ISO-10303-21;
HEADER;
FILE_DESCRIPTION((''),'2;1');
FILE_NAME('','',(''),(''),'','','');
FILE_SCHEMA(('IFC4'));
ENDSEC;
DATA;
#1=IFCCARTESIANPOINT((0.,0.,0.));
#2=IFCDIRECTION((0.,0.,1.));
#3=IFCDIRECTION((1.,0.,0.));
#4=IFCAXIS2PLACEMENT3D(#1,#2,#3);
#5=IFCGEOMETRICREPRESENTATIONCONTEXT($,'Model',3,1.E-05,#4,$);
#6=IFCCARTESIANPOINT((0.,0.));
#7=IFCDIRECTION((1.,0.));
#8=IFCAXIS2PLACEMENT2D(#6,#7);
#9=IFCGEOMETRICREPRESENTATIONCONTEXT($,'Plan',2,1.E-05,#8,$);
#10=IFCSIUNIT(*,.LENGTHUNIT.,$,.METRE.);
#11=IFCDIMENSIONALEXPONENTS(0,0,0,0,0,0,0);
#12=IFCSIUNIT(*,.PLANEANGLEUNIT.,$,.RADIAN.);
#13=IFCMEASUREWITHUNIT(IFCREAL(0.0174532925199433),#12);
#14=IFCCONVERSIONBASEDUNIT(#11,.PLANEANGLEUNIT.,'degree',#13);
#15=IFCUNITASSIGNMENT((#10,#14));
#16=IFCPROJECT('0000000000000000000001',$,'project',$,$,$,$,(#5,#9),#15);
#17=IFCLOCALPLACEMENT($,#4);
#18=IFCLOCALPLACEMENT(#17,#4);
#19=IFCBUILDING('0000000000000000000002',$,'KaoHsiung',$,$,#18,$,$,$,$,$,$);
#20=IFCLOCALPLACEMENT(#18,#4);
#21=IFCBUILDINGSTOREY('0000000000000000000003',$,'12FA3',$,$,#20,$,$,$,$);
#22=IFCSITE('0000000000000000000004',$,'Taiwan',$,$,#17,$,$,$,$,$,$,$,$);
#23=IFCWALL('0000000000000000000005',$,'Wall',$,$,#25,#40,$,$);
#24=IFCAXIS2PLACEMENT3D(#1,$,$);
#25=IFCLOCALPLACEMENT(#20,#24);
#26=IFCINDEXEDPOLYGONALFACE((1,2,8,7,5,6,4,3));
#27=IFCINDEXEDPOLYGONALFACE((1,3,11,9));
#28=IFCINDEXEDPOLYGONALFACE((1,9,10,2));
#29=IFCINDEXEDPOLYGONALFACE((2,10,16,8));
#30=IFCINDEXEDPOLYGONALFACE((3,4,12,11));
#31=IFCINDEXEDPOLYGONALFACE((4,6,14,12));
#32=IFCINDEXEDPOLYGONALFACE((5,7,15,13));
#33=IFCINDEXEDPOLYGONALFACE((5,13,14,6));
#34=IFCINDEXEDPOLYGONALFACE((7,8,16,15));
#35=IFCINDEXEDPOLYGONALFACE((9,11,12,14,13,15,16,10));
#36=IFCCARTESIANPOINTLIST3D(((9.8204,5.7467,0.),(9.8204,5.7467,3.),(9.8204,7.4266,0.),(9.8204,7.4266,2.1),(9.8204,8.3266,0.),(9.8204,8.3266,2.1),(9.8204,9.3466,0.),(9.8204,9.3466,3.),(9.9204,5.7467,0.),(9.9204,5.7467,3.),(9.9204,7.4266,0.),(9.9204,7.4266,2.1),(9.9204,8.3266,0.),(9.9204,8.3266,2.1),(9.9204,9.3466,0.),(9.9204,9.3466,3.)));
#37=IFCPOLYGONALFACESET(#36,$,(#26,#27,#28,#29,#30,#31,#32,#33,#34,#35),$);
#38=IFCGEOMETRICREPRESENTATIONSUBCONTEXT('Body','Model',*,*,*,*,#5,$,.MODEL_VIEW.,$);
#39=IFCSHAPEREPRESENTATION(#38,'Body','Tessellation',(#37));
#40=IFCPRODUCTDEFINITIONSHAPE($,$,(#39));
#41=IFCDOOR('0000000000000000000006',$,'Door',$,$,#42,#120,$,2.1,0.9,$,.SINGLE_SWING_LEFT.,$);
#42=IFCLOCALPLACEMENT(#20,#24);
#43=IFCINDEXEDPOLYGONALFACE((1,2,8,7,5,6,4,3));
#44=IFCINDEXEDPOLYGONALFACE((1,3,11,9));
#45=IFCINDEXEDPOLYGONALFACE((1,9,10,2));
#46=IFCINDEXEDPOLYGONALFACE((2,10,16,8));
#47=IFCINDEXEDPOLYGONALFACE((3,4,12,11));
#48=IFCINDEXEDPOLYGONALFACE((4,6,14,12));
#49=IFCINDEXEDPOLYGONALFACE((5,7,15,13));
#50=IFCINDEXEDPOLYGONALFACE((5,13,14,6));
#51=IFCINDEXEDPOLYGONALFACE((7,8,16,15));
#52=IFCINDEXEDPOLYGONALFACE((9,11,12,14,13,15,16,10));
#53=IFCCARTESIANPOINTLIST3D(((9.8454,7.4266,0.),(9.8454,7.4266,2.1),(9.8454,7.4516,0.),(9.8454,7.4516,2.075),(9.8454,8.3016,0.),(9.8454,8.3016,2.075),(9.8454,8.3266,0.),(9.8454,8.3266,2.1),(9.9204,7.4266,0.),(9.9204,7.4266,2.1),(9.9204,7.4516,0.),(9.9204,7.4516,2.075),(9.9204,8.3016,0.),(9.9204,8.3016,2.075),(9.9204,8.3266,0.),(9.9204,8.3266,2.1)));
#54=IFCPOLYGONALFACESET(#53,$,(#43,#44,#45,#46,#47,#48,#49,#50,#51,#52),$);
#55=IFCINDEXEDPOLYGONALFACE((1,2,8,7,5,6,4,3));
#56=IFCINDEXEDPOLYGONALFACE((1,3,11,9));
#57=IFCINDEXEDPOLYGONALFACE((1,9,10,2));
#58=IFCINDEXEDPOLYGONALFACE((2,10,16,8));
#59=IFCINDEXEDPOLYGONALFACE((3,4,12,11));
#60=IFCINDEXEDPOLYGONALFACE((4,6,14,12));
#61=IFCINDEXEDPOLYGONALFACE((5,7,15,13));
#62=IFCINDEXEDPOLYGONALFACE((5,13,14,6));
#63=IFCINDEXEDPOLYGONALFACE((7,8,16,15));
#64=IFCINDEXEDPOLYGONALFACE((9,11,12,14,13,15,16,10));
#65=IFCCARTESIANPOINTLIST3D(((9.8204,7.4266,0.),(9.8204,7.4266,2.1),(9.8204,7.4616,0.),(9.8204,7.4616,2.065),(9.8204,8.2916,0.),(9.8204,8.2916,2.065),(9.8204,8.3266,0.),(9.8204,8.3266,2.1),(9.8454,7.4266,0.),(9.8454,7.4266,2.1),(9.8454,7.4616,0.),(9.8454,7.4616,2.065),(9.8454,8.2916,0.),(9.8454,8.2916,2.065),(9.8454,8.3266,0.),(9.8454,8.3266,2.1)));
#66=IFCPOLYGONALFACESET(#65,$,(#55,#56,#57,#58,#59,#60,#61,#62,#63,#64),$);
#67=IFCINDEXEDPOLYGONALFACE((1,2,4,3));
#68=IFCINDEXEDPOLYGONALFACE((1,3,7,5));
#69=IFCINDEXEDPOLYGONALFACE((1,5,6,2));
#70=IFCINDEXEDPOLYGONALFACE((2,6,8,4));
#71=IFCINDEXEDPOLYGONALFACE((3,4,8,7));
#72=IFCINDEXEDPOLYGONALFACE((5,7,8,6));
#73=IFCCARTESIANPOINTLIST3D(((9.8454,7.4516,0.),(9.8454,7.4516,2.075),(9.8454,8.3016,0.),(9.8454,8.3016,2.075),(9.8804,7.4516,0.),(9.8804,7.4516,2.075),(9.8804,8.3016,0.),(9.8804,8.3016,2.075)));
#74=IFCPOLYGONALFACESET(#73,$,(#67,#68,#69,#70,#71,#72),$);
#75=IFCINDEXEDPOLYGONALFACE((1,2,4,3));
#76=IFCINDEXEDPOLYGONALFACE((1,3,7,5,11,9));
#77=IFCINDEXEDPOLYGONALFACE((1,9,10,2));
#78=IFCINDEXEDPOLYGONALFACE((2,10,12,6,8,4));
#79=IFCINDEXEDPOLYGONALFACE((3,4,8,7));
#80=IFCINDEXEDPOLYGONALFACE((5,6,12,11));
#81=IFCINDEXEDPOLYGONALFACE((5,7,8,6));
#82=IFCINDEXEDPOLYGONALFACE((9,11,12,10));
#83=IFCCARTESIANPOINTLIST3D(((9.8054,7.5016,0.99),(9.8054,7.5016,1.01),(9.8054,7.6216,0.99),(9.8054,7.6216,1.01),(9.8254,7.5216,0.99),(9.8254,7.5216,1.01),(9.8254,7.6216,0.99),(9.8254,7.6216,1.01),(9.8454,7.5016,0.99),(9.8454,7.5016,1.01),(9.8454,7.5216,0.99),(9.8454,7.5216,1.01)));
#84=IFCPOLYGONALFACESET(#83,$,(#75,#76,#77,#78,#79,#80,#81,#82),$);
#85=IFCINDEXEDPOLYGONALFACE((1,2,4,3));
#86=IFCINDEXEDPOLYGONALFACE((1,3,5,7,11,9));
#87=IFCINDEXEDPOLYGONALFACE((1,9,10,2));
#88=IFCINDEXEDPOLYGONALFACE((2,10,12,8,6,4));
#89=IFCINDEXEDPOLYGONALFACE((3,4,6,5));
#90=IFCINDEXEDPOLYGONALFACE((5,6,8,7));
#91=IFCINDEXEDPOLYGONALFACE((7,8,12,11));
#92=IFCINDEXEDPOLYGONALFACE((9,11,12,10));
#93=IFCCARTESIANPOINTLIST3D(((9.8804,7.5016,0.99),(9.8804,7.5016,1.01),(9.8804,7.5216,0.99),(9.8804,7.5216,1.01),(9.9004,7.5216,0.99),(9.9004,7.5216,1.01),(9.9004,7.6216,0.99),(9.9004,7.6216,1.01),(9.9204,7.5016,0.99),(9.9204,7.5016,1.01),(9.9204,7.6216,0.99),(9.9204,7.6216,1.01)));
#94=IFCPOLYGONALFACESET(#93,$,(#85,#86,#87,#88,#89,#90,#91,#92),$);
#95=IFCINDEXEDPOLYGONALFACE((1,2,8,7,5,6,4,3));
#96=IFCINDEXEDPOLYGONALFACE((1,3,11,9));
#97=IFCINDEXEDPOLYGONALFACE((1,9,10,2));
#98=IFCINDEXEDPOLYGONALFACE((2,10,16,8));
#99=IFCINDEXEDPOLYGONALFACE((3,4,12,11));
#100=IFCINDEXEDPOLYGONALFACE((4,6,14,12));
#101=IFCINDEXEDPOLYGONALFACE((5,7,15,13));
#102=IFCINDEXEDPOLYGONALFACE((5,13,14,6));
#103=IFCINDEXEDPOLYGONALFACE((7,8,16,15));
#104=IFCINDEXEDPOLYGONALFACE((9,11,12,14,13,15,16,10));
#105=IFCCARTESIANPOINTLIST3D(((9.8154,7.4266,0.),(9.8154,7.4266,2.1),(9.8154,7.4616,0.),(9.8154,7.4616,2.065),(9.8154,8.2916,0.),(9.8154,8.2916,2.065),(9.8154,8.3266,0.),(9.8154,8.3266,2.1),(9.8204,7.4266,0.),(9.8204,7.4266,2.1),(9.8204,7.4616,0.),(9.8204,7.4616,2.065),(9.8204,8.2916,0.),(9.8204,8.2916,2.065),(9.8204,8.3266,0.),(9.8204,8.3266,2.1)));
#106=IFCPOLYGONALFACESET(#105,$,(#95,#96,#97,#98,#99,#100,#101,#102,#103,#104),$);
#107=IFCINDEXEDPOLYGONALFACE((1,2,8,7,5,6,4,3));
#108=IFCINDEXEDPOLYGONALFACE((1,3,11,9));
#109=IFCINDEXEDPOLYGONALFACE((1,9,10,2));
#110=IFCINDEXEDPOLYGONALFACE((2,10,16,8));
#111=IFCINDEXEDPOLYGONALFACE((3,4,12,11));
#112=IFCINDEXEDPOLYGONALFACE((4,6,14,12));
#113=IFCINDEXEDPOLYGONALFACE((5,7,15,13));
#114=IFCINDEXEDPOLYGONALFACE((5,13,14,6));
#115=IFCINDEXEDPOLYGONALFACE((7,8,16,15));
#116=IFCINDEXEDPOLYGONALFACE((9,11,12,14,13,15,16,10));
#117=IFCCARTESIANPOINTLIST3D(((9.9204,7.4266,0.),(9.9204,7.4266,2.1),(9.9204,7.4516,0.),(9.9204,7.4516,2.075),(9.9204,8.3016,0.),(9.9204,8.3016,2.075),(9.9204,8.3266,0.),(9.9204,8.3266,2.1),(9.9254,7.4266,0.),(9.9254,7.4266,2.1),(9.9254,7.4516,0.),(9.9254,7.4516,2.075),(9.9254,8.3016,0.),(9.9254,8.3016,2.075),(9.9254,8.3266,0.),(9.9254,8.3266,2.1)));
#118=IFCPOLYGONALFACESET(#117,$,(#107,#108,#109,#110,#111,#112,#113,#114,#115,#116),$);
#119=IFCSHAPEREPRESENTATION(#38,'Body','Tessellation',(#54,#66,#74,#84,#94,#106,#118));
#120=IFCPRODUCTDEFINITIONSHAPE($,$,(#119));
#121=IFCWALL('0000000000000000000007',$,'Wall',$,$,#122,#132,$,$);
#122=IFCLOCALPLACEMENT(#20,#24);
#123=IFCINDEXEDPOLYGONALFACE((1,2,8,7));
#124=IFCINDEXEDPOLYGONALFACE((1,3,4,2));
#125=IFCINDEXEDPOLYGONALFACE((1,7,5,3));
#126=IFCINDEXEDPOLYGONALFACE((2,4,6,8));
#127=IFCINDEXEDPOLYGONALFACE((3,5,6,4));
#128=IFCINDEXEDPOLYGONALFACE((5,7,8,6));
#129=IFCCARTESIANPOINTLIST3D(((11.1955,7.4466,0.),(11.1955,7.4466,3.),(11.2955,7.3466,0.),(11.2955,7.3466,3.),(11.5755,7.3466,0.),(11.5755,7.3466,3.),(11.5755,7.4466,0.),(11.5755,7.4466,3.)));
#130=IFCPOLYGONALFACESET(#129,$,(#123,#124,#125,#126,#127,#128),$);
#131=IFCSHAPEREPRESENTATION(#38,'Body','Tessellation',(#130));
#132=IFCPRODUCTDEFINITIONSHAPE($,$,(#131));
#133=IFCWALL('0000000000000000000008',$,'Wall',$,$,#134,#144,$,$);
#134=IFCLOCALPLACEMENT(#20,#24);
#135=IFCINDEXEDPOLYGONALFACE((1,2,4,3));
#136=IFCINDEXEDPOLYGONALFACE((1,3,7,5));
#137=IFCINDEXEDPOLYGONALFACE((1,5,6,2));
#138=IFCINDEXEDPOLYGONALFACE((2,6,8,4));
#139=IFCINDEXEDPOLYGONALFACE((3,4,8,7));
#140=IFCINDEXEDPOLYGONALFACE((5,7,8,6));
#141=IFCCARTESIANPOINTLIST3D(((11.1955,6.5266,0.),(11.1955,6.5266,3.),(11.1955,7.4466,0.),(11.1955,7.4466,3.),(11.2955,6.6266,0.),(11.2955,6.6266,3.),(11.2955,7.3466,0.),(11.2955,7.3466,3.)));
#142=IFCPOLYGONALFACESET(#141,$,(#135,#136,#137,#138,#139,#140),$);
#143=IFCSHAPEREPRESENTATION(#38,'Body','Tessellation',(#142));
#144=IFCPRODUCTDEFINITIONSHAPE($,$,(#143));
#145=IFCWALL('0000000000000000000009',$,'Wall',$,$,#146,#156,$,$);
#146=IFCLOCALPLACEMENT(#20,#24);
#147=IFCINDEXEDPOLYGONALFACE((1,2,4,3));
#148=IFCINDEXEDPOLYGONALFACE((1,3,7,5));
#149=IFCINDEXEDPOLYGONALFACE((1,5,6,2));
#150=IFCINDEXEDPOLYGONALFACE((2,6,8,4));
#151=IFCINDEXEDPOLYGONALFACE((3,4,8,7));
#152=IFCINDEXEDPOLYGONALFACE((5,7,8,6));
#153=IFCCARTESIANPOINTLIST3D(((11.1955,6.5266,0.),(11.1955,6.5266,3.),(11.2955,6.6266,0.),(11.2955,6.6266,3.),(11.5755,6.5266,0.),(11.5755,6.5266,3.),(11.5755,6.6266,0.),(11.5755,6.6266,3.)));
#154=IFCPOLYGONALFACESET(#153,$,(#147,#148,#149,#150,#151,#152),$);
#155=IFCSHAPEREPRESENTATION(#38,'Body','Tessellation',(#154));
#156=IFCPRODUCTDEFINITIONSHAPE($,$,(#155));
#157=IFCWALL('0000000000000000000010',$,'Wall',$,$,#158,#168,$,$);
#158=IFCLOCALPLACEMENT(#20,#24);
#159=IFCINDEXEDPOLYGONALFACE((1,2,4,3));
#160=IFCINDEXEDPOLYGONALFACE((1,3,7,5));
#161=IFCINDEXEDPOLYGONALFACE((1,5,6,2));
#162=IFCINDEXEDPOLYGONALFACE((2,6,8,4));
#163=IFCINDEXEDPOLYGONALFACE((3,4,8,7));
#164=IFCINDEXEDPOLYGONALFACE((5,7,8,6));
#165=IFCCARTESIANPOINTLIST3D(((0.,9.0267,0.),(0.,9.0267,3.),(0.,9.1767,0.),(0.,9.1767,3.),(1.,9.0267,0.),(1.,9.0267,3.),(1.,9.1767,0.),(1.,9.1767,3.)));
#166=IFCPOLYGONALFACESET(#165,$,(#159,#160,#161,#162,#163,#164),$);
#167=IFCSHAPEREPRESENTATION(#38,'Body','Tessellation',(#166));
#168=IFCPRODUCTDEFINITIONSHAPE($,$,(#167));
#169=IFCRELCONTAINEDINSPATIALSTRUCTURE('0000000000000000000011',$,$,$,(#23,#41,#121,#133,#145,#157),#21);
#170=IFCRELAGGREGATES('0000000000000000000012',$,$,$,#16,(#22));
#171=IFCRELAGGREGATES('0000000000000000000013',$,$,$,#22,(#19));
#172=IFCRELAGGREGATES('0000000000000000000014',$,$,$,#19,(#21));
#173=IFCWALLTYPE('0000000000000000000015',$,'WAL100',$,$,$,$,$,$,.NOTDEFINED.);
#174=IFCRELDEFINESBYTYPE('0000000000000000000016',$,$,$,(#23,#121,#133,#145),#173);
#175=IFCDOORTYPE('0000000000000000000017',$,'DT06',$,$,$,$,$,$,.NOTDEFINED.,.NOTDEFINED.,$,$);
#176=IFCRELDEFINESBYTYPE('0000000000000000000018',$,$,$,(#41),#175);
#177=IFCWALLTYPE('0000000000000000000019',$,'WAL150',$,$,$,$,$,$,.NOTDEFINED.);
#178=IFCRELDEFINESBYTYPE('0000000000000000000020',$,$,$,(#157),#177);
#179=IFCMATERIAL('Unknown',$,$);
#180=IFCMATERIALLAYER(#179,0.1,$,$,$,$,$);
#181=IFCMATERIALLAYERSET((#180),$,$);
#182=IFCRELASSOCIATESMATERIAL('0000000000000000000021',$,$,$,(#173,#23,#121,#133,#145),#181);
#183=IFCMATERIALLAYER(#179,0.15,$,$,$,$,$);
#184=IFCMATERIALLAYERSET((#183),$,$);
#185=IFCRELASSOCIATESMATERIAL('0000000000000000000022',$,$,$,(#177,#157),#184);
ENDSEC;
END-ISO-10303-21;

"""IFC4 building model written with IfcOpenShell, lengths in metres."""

from ifc_helpers import new_model, entity, si_unit, converted_unit, frame, origin_with_axes, origin_2d_with_axis, place, context, subcontext, project, spatial, line, indexed_curve, outline, extrude, shape, source, transform, mapped, material, layer, layer_set, layer_usage, type_object, type_shapes, element, fill, save


model = new_model("IFC4")

# Units and contexts
model_context = context("Model", 3, precision=1e-05, world=origin_with_axes())
plan_context = context("Plan", 2, precision=1e-05, world=origin_2d_with_axis())
body_context_1 = subcontext(model_context, "Body", "Model", "MODEL_VIEW")
body_context_2 = subcontext(plan_context, "Body", "Plan", "PLAN_VIEW")
ifc_project = project(units=[si_unit("LENGTHUNIT", "METRE"), converted_unit("PLANEANGLEUNIT", "degree", entity("IfcReal", 0.0174532925199433), si_unit("PLANEANGLEUNIT", "RADIAN"), dimensions=[0, 0, 0, 0, 0, 0, 0])], contexts=[model_context, plan_context])

# Site, building, storey
site_placement = place(None, origin_with_axes())
site = spatial("IfcSite", under=ifc_project, at=site_placement, Name="Taiwan")
building_placement = place(site_placement, origin_with_axes())
building = spatial("IfcBuilding", under=site, at=building_placement, Name="KaoHsiung")
storey_placement = place(building_placement, origin_with_axes())
storey = spatial("IfcBuildingStorey", under=building, at=storey_placement, Name="12FA3")

# Shared definitions
ifc_material = material(Name="Unknown")

# Shared definitions
ifc_layer_1 = layer(ifc_material, 0.1)
ifc_layer_set_1 = layer_set([ifc_layer_1])
wall_type_1 = type_object("IfcWallType", Name="WAL100", PredefinedType="NOTDEFINED", material=ifc_layer_set_1)

# Wall, opening, door
ifc_layer_usage_1 = layer_usage(ifc_layer_set_1, "AXIS2", "POSITIVE", 0.0)
wall_1_placement = place(storey_placement, frame((9.8204, 9.3466, 0.0), z_axis=(0.0, 0.0, 1.0), x_axis=(0.0, -1.0, 0.0)))
wall_1 = element("IfcWall", 1, at=wall_1_placement, inside=storey, type_object=wall_type_1, material=ifc_layer_usage_1, Name="Wall", context=body_context_1, shape_type="SweptSolid", body=[
    extrude(outline(indexed_curve([(0.0, 0.0), (0.0, 0.1), (3.5999, 0.1), (3.5999, 0.0)], segments=[line(1, 2, 3, 4, 1)])), origin_with_axes(), (0.0, 0.0, 1.0), 3.0),
])
shared_shape_1 = source(origin_with_axes(), body_context_1, "Body", "SweptSolid", [
    extrude(outline(indexed_curve([(0.0, 0.0), (0.9, 0.0), (0.9, 2.1), (0.0, 2.1)], segments=[line(1, 2, 3, 4, 1)])), frame((0.0, -0.6, 0.0), z_axis=(0.0, -1.0, 0.0), x_axis=(1.0, 0.0, 0.0)), (0.0, 0.0, -1.0), 1.2),
])
opening_1_placement = place(wall_1_placement, frame((1.0199, 0.0, 0.0), z_axis=(0.0, 0.0, 1.0), x_axis=(1.0, 0.0, 0.0)))
opening_1 = element("IfcOpeningElement", 2, at=opening_1_placement, cuts=wall_1, PredefinedType="OPENING", context=body_context_1, shape_type="MappedRepresentation", body=[
    mapped(shared_shape_1, transform((0.0, 0.0, 0.0), x_axis=(1.0, 0.0, 0.0), y_axis=(0.0, 1.0, 0.0), z_axis=(0.0, 0.0, 1.0), scale=1.0)),
])
door_type_1 = type_object("IfcDoorType", Name="DT06", OperationType="NOTDEFINED", PredefinedType="NOTDEFINED")
shared_shape_2 = source(origin_with_axes(), body_context_1, "Body", "SweptSolid", [
    extrude(outline(indexed_curve([(0.0, 0.0), (0.0, 2.1), (0.9, 2.1), (0.9, 0.0), (0.875, 0.0), (0.875, 2.075), (0.025, 2.075), (0.025, 0.0)], segments=[line(1, 2, 3, 4, 5, 6, 7, 8, 1)])), frame((0.0, 0.025, 0.0), z_axis=(0.0, -1.0, 0.0), x_axis=(1.0, 0.0, 0.0)), (0.0, 0.0, -1.0), 0.075),
    extrude(outline(indexed_curve([(0.0, 0.0), (0.0, 2.1), (0.9, 2.1), (0.9, 0.0), (0.865, 0.0), (0.865, 2.065), (0.035, 2.065), (0.035, 0.0)], segments=[line(1, 2, 3, 4, 5, 6, 7, 8, 1)])), frame((0.0, 0.0, 0.0), z_axis=(0.0, -1.0, 0.0), x_axis=(1.0, 0.0, 0.0)), (0.0, 0.0, -1.0), 0.025),
    extrude(outline(indexed_curve([(0.0, 0.0), (0.85, 0.0), (0.85, 0.035), (0.0, 0.035)], segments=[line(1, 2, 3, 4, 1)])), frame((0.025, 0.025, 0.0), z_axis=(0.0, 0.0, 1.0), x_axis=(1.0, 0.0, 0.0)), (0.0, 0.0, 1.0), 2.075),
    extrude(outline(indexed_curve([(0.0, 0.0), (0.0, -0.04), (-0.12, -0.04), (-0.12, -0.02), (-0.02, -0.02), (-0.02, 0.0)], segments=[line(1, 2, 3, 4, 5, 6, 1)])), frame((0.825, 0.025, 0.99), z_axis=(0.0, 0.0, 1.0), x_axis=(1.0, 0.0, 0.0)), (0.0, 0.0, 1.0), 0.02),
    extrude(outline(indexed_curve([(0.0, 0.0), (0.0, 0.04), (-0.12, 0.04), (-0.12, 0.02), (-0.02, 0.02), (-0.02, 0.0)], segments=[line(1, 2, 3, 4, 5, 6, 1)])), frame((0.825, 0.06, 0.99), z_axis=(0.0, 0.0, 1.0), x_axis=(1.0, 0.0, 0.0)), (0.0, 0.0, 1.0), 0.02),
    extrude(outline(indexed_curve([(0.0, 0.0), (0.0, 2.1), (0.9, 2.1), (0.9, 0.0), (0.865, 0.0), (0.865, 2.065), (0.035, 2.065), (0.035, 0.0)], segments=[line(1, 2, 3, 4, 5, 6, 7, 8, 1)])), frame((0.0, -0.005, 0.0), z_axis=(0.0, -1.0, 0.0), x_axis=(1.0, 0.0, 0.0)), (0.0, 0.0, -1.0), 0.005),
    extrude(outline(indexed_curve([(0.0, 0.0), (0.0, 2.1), (0.9, 2.1), (0.9, 0.0), (0.875, 0.0), (0.875, 2.075), (0.025, 2.075), (0.025, 0.0)], segments=[line(1, 2, 3, 4, 5, 6, 7, 8, 1)])), frame((0.0, 0.1, 0.0), z_axis=(0.0, -1.0, 0.0), x_axis=(1.0, 0.0, 0.0)), (0.0, 0.0, -1.0), 0.005),
])
shared_shape_3 = source(origin_with_axes(), body_context_2, "Body", "Curve2D", [
    entity("IfcIndexedPolyCurve", entity("IfcCartesianPointList2D", [[0.0, 0.0], [0.0, 0.1], [0.025, 0.1], [0.025, 0.025], [0.035, 0.025], [0.035, 0.0]]), [entity("IfcLineIndex", [1, 2, 3, 4, 5, 6, 1])]),
    entity("IfcIndexedPolyCurve", entity("IfcCartesianPointList2D", [[0.9, 0.0], [0.9, 0.1], [0.875, 0.1], [0.875, 0.025], [0.865, 0.025], [0.865, 0.0]]), [entity("IfcLineIndex", [1, 2, 3, 4, 5, 6, 1])]),
    entity("IfcTrimmedCurve", entity("IfcEllipse", entity("IfcAxis2Placement2D", entity("IfcCartesianPoint", [0.06, 0.1]), entity("IfcDirection", [1.0, 0.0])), 0.815, 0.85), [entity("IfcCartesianPoint", [0.875, 0.1])], [entity("IfcCartesianPoint", [0.06, 0.95])], True, "CARTESIAN"),
    entity("IfcIndexedPolyCurve", entity("IfcCartesianPointList2D", [[0.025, 0.1], [0.06, 0.1], [0.06, 0.95], [0.025, 0.95]]), [entity("IfcLineIndex", [1, 2, 3, 4, 1])]),
])
type_shapes(door_type_1, [shared_shape_2, shared_shape_3])
door_1_placement = place(opening_1_placement, origin_with_axes())
door_1 = element("IfcDoor", 3, at=door_1_placement, inside=storey, type_object=door_type_1, Name="Door", OperationType="SINGLE_SWING_LEFT", OverallHeight=2.1, OverallWidth=0.9, shapes=[
    shape(body_context_1, "Body", "MappedRepresentation", [mapped(shared_shape_2, transform((0.0, 0.0, 0.0), x_axis=(1.0, 0.0, 0.0), y_axis=(0.0, 1.0, 0.0), z_axis=(0.0, 0.0, 1.0), scale=1.0))]),
    shape(body_context_2, "Body", "MappedRepresentation", [mapped(shared_shape_3, transform((0.0, 0.0, 0.0), x_axis=(1.0, 0.0, 0.0), y_axis=(0.0, 1.0, 0.0), z_axis=(0.0, 0.0, 1.0), scale=1.0))]),
])
fill(opening_1, door_1)

# Walls
ifc_layer_usage_2 = layer_usage(ifc_layer_set_1, "AXIS2", "POSITIVE", 0.0)
wall_2_placement = place(storey_placement, frame((11.5755, 7.4466, 0.0), z_axis=(0.0, 0.0, 1.0), x_axis=(-1.0, 0.0, 0.0)))
element("IfcWall", 4, at=wall_2_placement, inside=storey, type_object=wall_type_1, material=ifc_layer_usage_2, Name="Wall", context=body_context_1, shape_type="SweptSolid", body=[
    extrude(outline(indexed_curve([(0.0, 0.0), (0.0, 0.1), (0.28, 0.1), (0.38, 0.0)], segments=[line(1, 2, 3, 4, 1)])), origin_with_axes(), (0.0, 0.0, 1.0), 3.0),
])
ifc_layer_usage_3 = layer_usage(ifc_layer_set_1, "AXIS2", "POSITIVE", 0.0)
wall_3_placement = place(storey_placement, frame((11.1955, 7.4466, 0.0), z_axis=(0.0, 0.0, 1.0), x_axis=(0.0, -1.0, 0.0)))
element("IfcWall", 5, at=wall_3_placement, inside=storey, type_object=wall_type_1, material=ifc_layer_usage_3, Name="Wall", context=body_context_1, shape_type="SweptSolid", body=[
    extrude(outline(indexed_curve([(0.0, 0.0), (0.1, 0.1), (0.82, 0.1), (0.92, 0.0)], segments=[line(1, 2, 3, 4, 1)])), origin_with_axes(), (0.0, 0.0, 1.0), 3.0),
])
ifc_layer_usage_4 = layer_usage(ifc_layer_set_1, "AXIS2", "POSITIVE", 0.0)
wall_4_placement = place(storey_placement, frame((11.1955, 6.5266, 0.0), z_axis=(0.0, 0.0, 1.0), x_axis=(1.0, 0.0, 0.0)))
element("IfcWall", 6, at=wall_4_placement, inside=storey, type_object=wall_type_1, material=ifc_layer_usage_4, Name="Wall", context=body_context_1, shape_type="SweptSolid", body=[
    extrude(outline(indexed_curve([(0.0, 0.0), (0.1, 0.1), (0.38, 0.1), (0.38, 0.0)], segments=[line(1, 2, 3, 4, 1)])), origin_with_axes(), (0.0, 0.0, 1.0), 3.0),
])
ifc_layer_2 = layer(ifc_material, 0.15)
ifc_layer_set_2 = layer_set([ifc_layer_2])
ifc_layer_usage_5 = layer_usage(ifc_layer_set_2, "AXIS2", "POSITIVE", 0.0)
wall_type_2 = type_object("IfcWallType", Name="WAL150", PredefinedType="NOTDEFINED", material=ifc_layer_set_2)
wall_5_placement = place(storey_placement, frame((0.0, 9.0267, 0.0), z_axis=(0.0, 0.0, 1.0), x_axis=(1.0, 0.0, 0.0)))
element("IfcWall", 7, at=wall_5_placement, inside=storey, type_object=wall_type_2, material=ifc_layer_usage_5, Name="Wall", context=body_context_1, shape_type="SweptSolid", body=[
    extrude(outline(indexed_curve([(0.0, 0.0), (0.0, 0.15), (1.0, 0.15), (1.0, 0.0)], segments=[line(1, 2, 3, 4, 1)])), origin_with_axes(), (0.0, 0.0, 1.0), 3.0),
])

save(model, "model.ifc")
